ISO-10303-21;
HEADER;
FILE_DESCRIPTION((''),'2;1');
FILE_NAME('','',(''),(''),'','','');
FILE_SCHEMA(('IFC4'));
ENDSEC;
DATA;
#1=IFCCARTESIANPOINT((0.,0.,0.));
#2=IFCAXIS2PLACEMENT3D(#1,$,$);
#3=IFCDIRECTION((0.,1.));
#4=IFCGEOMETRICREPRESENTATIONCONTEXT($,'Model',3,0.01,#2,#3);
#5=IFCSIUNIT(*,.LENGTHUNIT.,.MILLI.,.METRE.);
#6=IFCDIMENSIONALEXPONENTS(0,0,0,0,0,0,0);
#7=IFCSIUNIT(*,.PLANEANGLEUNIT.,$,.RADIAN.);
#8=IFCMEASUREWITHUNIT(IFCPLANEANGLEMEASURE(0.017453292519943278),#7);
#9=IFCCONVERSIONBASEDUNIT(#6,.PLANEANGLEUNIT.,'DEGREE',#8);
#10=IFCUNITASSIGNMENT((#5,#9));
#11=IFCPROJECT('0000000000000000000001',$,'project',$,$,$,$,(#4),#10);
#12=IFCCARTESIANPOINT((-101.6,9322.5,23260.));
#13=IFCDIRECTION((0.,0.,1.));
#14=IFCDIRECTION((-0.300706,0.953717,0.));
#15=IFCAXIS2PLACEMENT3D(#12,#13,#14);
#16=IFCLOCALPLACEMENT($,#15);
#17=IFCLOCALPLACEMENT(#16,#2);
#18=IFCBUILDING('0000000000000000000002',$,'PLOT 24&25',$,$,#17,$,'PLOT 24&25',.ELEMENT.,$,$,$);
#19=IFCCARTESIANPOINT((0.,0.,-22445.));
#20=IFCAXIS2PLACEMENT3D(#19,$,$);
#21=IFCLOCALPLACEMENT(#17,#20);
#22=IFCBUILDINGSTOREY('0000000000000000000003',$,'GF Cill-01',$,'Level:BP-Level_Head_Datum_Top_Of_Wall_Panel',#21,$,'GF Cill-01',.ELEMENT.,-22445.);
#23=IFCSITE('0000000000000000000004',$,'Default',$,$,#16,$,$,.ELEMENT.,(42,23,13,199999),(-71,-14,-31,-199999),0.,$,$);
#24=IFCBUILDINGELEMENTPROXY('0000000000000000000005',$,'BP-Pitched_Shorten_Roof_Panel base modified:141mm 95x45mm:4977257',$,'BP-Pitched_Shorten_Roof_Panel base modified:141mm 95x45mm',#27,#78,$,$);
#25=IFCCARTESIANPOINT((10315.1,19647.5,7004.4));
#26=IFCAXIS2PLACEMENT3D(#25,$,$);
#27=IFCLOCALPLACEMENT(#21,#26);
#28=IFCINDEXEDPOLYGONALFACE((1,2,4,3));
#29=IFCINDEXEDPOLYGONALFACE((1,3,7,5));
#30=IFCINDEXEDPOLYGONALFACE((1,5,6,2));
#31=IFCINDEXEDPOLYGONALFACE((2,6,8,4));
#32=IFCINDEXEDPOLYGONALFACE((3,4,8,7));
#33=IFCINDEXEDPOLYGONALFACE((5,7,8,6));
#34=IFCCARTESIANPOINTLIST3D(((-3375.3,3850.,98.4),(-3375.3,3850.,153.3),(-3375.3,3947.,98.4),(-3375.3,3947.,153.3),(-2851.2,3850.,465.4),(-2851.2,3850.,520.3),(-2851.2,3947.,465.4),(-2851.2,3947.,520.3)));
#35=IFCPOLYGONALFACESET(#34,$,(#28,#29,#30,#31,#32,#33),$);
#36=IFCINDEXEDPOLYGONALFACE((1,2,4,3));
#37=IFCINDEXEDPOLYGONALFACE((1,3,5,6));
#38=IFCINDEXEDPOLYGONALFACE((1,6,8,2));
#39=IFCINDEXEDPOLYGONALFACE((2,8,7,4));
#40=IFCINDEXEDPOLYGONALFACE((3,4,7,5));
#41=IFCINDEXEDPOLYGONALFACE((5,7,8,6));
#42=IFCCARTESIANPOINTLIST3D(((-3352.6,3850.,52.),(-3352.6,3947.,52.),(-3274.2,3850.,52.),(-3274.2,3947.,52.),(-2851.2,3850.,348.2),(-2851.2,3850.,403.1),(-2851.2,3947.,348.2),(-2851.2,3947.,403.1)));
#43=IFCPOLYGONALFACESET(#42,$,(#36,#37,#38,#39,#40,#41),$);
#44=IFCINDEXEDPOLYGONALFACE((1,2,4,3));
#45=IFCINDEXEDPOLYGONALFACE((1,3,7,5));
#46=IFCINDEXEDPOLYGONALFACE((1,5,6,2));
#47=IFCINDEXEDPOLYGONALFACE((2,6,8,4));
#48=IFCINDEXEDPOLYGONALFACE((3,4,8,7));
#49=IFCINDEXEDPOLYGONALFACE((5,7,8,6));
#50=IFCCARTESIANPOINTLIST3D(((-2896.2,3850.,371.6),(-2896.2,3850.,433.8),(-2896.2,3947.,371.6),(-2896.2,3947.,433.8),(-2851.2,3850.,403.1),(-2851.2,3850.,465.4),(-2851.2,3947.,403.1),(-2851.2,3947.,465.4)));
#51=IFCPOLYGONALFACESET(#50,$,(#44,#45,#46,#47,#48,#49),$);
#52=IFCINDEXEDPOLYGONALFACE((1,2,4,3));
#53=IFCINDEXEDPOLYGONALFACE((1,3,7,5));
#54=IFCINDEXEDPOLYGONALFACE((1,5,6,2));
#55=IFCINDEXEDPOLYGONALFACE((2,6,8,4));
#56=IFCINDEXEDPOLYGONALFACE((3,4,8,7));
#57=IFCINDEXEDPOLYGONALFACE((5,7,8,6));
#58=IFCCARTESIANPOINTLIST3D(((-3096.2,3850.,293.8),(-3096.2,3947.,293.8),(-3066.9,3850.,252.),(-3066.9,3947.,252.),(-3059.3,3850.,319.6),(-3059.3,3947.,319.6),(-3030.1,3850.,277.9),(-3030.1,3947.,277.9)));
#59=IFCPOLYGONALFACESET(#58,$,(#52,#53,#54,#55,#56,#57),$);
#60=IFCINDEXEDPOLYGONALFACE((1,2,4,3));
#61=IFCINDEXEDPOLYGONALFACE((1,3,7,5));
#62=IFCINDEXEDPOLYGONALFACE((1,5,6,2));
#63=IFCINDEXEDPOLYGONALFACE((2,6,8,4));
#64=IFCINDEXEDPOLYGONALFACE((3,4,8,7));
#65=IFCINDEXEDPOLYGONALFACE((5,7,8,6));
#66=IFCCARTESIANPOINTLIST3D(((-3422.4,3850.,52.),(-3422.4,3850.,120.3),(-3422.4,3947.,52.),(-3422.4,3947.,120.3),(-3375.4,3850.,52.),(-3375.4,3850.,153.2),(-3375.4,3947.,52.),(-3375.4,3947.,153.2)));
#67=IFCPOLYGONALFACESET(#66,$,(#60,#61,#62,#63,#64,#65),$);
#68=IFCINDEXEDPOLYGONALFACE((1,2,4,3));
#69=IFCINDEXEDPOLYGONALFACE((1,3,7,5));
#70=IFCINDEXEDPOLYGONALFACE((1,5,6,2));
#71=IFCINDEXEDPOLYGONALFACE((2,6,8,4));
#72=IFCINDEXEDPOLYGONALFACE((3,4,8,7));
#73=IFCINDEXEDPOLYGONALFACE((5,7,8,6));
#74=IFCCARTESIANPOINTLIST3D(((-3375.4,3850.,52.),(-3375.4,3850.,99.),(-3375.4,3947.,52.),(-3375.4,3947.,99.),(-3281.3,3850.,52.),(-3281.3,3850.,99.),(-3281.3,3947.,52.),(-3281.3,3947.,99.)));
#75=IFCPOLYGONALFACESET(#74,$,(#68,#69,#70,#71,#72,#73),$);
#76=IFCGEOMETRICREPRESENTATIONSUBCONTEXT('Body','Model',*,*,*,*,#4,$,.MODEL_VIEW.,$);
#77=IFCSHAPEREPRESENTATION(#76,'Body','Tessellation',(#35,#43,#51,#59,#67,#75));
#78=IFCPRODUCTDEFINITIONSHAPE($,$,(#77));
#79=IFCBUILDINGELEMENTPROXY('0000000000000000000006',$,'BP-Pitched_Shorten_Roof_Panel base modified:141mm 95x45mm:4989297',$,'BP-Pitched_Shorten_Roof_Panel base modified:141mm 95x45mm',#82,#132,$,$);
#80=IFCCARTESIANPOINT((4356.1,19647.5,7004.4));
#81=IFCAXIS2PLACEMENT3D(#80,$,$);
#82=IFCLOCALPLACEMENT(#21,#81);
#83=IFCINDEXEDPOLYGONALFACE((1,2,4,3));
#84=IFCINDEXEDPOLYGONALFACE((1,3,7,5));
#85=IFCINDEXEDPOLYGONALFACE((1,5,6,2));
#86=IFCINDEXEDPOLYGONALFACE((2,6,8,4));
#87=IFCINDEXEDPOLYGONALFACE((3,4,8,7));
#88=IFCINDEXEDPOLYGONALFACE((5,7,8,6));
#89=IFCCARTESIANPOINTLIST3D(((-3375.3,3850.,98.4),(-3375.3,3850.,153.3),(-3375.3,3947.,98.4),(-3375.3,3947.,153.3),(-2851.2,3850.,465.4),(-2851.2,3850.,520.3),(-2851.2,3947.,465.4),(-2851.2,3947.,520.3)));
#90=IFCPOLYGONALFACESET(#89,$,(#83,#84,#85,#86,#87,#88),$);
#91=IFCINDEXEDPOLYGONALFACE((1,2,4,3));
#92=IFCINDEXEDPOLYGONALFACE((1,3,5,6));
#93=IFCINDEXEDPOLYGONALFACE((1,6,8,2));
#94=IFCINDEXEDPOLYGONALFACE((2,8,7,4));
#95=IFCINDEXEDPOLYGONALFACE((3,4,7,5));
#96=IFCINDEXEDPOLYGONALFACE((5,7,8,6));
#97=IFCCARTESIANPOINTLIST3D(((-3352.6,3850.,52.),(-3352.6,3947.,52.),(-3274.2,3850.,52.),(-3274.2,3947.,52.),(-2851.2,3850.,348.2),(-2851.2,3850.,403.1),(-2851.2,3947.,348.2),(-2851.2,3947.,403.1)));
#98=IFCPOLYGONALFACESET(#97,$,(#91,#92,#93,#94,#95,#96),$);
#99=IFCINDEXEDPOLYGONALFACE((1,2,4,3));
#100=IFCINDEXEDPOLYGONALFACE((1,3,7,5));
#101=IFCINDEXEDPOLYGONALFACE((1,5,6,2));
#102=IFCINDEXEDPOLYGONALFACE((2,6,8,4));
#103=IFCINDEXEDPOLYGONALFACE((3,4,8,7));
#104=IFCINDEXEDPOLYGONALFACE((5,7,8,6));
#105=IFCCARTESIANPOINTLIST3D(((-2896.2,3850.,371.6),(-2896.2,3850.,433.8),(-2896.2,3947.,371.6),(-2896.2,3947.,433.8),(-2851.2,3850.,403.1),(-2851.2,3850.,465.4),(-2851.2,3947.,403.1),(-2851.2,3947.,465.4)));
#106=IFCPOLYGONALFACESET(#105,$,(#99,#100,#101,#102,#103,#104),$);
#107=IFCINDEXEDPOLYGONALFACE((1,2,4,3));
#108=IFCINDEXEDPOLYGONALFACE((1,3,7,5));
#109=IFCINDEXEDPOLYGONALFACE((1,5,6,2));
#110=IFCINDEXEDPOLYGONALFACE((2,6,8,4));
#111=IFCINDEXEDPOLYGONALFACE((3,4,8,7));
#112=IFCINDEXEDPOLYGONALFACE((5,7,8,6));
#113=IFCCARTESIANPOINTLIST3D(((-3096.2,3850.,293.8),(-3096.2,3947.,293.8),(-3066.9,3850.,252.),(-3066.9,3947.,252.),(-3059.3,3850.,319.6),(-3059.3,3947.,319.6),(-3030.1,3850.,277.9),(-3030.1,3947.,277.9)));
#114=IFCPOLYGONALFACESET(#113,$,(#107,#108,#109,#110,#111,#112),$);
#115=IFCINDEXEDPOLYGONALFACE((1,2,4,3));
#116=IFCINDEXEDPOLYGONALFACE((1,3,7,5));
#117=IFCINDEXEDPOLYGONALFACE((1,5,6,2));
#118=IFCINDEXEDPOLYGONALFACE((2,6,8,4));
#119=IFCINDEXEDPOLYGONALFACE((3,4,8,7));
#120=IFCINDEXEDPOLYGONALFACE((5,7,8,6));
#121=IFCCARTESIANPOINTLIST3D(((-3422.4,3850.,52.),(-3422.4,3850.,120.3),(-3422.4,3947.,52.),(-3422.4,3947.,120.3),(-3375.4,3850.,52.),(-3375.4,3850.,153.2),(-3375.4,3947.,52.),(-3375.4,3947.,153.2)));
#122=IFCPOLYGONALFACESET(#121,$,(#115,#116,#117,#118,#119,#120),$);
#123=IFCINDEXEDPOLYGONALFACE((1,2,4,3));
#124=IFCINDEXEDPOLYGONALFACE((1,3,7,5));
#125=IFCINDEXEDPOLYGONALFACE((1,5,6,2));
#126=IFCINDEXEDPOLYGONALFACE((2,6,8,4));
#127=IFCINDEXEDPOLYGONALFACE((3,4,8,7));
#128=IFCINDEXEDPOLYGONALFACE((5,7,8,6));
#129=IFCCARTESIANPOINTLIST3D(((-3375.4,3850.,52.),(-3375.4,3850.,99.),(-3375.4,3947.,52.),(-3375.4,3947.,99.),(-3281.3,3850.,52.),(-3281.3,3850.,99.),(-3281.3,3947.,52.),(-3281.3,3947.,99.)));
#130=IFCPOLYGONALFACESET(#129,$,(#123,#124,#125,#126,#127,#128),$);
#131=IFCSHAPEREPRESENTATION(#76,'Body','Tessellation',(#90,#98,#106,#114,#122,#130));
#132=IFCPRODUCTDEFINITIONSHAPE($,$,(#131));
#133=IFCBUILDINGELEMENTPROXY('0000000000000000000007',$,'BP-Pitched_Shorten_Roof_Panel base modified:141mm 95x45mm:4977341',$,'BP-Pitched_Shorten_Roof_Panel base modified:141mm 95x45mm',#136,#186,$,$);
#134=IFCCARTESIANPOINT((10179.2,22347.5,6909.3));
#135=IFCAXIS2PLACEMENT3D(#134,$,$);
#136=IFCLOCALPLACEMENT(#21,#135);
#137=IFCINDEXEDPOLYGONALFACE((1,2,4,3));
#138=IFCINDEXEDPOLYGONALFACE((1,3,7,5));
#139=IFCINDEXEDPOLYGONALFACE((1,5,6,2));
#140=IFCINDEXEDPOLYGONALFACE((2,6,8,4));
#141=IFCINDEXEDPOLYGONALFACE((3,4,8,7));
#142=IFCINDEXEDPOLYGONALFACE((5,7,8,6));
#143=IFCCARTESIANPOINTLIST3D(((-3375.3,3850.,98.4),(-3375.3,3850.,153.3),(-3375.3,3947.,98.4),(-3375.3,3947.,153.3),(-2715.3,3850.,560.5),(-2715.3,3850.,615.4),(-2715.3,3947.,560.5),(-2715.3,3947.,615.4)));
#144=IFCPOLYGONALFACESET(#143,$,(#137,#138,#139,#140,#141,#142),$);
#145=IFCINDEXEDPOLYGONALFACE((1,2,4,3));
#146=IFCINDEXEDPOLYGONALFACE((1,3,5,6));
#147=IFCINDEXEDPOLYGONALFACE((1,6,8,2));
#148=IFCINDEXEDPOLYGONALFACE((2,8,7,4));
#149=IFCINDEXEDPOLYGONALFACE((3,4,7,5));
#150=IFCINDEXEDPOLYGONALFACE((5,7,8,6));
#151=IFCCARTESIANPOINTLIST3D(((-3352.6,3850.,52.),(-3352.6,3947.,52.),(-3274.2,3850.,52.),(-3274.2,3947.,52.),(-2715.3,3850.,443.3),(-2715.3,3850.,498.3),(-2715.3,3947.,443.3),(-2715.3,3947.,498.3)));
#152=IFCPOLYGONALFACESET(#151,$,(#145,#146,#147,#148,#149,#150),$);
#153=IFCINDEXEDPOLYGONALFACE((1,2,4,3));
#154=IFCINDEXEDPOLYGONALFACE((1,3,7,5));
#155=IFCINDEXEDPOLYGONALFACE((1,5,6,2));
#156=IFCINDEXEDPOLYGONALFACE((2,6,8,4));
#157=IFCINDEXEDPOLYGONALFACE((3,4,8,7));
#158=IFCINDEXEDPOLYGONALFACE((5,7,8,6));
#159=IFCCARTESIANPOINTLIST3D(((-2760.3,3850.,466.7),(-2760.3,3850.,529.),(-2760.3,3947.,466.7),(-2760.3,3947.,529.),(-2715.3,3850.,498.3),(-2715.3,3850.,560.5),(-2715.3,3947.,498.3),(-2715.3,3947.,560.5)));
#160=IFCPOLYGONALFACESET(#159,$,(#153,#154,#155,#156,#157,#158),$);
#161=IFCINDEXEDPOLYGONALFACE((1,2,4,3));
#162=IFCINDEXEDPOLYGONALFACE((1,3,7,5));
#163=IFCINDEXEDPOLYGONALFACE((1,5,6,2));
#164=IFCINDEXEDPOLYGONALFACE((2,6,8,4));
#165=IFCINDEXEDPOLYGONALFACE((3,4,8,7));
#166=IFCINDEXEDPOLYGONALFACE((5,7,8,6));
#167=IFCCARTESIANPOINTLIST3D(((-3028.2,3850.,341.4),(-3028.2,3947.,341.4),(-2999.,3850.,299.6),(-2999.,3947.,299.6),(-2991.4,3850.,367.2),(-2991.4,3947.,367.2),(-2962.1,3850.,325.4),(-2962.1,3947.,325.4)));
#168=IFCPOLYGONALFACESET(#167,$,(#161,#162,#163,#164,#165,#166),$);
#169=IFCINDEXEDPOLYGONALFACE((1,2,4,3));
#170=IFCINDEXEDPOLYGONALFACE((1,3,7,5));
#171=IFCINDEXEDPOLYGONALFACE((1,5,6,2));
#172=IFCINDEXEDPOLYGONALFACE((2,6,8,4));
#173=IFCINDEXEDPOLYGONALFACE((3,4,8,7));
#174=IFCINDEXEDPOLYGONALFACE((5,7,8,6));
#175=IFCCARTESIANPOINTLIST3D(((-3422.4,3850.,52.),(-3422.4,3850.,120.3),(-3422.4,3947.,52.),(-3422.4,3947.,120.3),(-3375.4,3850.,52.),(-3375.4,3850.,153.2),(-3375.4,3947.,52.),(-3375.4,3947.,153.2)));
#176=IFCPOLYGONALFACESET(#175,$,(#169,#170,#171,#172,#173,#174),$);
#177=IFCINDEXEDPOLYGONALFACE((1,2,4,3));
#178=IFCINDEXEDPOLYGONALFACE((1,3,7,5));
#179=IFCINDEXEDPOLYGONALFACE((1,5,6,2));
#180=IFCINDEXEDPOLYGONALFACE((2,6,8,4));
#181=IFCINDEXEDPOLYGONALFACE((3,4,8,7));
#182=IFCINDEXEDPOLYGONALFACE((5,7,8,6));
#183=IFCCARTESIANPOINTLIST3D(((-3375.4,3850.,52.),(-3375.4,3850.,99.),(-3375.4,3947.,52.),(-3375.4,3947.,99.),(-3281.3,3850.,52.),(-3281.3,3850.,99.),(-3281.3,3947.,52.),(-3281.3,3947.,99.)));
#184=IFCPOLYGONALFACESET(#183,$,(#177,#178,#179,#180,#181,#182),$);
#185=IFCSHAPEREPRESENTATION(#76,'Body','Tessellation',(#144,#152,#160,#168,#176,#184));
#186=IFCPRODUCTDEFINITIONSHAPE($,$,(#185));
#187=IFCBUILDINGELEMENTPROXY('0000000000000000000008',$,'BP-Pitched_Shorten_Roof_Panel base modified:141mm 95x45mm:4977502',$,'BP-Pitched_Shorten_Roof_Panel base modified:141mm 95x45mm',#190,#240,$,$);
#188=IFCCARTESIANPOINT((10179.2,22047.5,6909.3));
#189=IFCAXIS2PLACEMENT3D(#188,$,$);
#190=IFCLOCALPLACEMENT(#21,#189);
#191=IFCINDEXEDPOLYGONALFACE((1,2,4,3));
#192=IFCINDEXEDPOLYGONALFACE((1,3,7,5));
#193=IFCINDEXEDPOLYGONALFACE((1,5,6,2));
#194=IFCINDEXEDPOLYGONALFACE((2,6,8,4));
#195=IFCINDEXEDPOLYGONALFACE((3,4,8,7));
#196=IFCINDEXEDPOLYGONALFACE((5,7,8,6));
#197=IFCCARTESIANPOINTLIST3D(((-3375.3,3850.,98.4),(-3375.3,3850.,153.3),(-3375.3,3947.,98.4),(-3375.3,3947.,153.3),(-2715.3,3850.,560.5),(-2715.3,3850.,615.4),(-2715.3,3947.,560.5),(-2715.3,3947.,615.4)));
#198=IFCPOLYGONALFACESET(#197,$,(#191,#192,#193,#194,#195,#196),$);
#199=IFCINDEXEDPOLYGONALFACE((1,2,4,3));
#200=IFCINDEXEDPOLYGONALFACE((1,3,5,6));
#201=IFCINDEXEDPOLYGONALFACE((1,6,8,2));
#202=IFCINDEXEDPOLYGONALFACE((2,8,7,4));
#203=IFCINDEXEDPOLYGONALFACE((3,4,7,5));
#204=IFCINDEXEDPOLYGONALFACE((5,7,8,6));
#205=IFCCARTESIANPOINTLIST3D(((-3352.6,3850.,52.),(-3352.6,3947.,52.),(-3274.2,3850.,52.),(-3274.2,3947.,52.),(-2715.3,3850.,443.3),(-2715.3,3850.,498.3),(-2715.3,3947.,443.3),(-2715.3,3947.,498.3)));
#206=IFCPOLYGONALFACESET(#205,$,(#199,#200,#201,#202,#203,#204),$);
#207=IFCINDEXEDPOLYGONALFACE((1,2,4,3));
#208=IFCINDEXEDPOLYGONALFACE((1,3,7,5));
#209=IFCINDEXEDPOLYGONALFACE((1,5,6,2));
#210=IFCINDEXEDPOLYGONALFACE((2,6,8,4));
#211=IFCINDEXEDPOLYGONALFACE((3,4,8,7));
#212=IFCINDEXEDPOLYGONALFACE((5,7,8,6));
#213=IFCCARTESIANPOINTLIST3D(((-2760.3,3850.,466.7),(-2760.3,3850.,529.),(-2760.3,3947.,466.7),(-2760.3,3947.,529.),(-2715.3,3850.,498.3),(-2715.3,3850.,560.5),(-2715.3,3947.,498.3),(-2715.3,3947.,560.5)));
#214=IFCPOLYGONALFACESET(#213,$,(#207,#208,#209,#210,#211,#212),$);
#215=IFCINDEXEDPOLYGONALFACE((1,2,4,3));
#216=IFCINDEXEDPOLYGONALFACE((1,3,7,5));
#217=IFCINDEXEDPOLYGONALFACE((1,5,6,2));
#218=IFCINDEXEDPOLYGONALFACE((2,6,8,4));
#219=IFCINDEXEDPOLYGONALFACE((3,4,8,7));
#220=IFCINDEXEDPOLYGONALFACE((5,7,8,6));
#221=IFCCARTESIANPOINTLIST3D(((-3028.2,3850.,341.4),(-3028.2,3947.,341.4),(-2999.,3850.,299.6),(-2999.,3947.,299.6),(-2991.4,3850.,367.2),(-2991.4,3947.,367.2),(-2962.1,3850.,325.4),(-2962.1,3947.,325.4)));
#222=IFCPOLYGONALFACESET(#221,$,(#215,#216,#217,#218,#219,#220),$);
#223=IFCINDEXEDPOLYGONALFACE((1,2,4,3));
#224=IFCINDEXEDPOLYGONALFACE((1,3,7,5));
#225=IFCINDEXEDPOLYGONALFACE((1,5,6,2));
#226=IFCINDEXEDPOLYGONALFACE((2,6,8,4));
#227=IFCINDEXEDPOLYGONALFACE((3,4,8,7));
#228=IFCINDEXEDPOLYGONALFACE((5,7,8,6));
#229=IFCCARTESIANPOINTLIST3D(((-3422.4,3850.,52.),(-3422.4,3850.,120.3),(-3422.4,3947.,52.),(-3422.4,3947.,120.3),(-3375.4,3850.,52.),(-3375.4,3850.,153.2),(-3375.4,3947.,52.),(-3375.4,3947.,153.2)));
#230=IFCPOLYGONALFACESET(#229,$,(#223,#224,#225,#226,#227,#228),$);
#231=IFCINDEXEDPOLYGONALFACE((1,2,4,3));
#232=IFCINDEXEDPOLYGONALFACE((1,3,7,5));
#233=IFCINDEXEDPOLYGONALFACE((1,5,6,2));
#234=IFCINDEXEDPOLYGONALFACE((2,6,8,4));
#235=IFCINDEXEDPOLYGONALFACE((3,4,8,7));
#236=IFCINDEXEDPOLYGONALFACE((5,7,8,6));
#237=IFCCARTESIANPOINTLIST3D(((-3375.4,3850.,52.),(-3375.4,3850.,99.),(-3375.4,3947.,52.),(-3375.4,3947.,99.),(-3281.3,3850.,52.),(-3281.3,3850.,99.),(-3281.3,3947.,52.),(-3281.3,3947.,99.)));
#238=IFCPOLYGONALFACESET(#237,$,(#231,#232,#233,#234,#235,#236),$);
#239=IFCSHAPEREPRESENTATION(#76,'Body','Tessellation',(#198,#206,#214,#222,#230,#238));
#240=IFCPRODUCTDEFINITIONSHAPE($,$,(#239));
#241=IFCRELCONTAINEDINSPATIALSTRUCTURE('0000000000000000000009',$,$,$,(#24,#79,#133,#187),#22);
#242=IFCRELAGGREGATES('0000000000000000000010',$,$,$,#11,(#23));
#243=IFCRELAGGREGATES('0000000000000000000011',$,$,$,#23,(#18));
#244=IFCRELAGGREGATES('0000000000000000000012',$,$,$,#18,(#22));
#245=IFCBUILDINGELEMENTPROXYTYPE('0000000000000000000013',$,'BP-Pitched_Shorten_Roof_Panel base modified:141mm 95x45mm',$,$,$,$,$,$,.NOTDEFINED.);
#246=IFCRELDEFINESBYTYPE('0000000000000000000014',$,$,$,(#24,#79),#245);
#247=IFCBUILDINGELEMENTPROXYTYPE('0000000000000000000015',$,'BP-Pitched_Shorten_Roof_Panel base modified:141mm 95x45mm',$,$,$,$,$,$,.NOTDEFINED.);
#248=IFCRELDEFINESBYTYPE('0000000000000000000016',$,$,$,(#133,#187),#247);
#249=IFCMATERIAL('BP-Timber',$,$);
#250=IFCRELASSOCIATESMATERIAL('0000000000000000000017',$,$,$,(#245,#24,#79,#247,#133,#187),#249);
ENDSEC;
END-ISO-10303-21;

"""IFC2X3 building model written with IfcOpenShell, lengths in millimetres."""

from ifc_helpers import new_model, entity, si_unit, converted_unit, direction, frame, frame_2d, origin, origin_2d_with_axis, place, context, subcontext, project, spatial, polyline, rectangle, outline, extrude, source, transform, mapped, material, type_object, type_shapes, element, save


model = new_model("IFC2X3")

# Units and contexts
model_context = context("Model", 3, precision=0.01, world=origin(), true_north=direction((0.0, 1.0)))
body_context = subcontext(model_context, "Body", "Model", "MODEL_VIEW")
ifc_project = project(units=[si_unit("LENGTHUNIT", "METRE", prefix="MILLI"), converted_unit("PLANEANGLEUNIT", "DEGREE", entity("IfcPlaneAngleMeasure", 0.017453292519943278), si_unit("PLANEANGLEUNIT", "RADIAN"), dimensions=[0, 0, 0, 0, 0, 0, 0])], contexts=[model_context])

# Site, building, storey
site_placement = place(None, frame((-101.6, 9322.5, 23260.0), z_axis=(0.0, 0.0, 1.0), x_axis=(-0.300706, 0.953717, 0.0)))
site = spatial("IfcSite", under=ifc_project, at=site_placement, Name="Default", CompositionType="ELEMENT", RefLatitude=(42, 23, 13, 199999), RefLongitude=(-71, -14, -31, -199999), RefElevation=0.0)
building_placement = place(site_placement, origin())
building = spatial("IfcBuilding", under=site, at=building_placement, Name="PLOT 24&25", LongName="PLOT 24&25", CompositionType="ELEMENT")
storey_placement = place(building_placement, frame((0.0, 0.0, -22445.0)))
storey = spatial("IfcBuildingStorey", under=building, at=storey_placement, Name="GF Cill-01", ObjectType="Level:BP-Level_Head_Datum_Top_Of_Wall_Panel", LongName="GF Cill-01", CompositionType="ELEMENT", Elevation=-22445.0)

# Shared definitions
ifc_material_1 = material(Name="BP-Timber")

# Building element proxies
building_element_proxy_type_1 = type_object("IfcBuildingElementProxyType", Name="BP-Pitched_Shorten_Roof_Panel base modified:141mm 95x45mm", PredefinedType="NOTDEFINED", material=ifc_material_1)
shared_shape_1 = source(origin(), body_context, "Body", "SweptSolid", [
    extrude(outline(polyline([(-211.0, -262.0), (-156.0, -262.0), (211.0, 262.0), (156.0, 262.0), (-211.0, -262.0)])), frame((-3113.3, 3850.0, 309.3), z_axis=(0.0, 1.0, 0.0), x_axis=(0.0, 0.0, -1.0)), (0.0, 0.0, 1.0), 97.0),
    extrude(outline(polyline([(-189.3, -231.1), (-134.3, -231.1), (161.8, 191.9), (161.8, 270.3), (-189.3, -231.1)])), frame((-3082.3, 3850.0, 213.8), z_axis=(0.0, 1.0, 0.0), x_axis=(0.0, 0.0, -1.0)), (0.0, 0.0, 1.0), 97.0),
    extrude(outline(polyline([(-9.6, -25.5), (45.3, -25.5), (9.6, 25.5), (-45.3, 25.5), (-9.6, -25.5)])), frame((-2873.7, 3850.0, 418.5), z_axis=(0.0, 1.0, 0.0), x_axis=(0.819152, 0.0, 0.573576)), (0.0, 0.0, 1.0), 97.0),
    extrude(rectangle(XDim=51.0, YDim=45.0, at=frame_2d((0.0, 0.0), x_axis=(1.0, 0.0))), frame((-3063.1, 3850.0, 285.8), z_axis=(0.0, 1.0, 0.0), x_axis=(0.573576, 0.0, -0.819152)), (0.0, 0.0, 1.0), 97.0),
    extrude(outline(polyline([(-58.9, -23.5), (42.4, -23.5), (42.4, 23.5), (-25.9, 23.5), (-58.9, -23.5)])), frame((-3398.9, 3850.0, 94.4), z_axis=(0.0, 1.0, 0.0), x_axis=(0.0, 0.0, -1.0)), (0.0, 0.0, 1.0), 97.0),
    extrude(rectangle(XDim=97.0, YDim=94.1, at=frame_2d((0.0, 0.0), x_axis=(1.0, 0.0))), frame((-3328.4, 3898.5, 52.0), z_axis=(0.0, 0.0, 1.0), x_axis=(0.0, 1.0, 0.0)), (0.0, 0.0, 1.0), 47.0),
])
type_shapes(building_element_proxy_type_1, [shared_shape_1])
for number, where, name in (
    (1, (10315.1, 19647.5, 7004.4), "BP-Pitched_Shorten_Roof_Panel base modified:141mm 95x45mm:4977257"),
    (2, (4356.1, 19647.5, 7004.4), "BP-Pitched_Shorten_Roof_Panel base modified:141mm 95x45mm:4989297"),
):
    element("IfcBuildingElementProxy", number, at=place(storey_placement, frame(where)), inside=storey, type_object=building_element_proxy_type_1, material=ifc_material_1, Name=name, ObjectType="BP-Pitched_Shorten_Roof_Panel base modified:141mm 95x45mm", context=body_context, shape_type="MappedRepresentation", body=[
        mapped(shared_shape_1, transform((0.0, 0.0, 0.0), scale=1.0)),
    ])
building_element_proxy_type_2 = type_object("IfcBuildingElementProxyType", Name="BP-Pitched_Shorten_Roof_Panel base modified:141mm 95x45mm", PredefinedType="NOTDEFINED", material=ifc_material_1)
shared_shape_2 = source(origin(), body_context, "Body", "SweptSolid", [
    extrude(outline(polyline([(-258.5, -330.0), (-203.6, -330.0), (258.5, 330.0), (203.6, 330.0), (-258.5, -330.0)])), frame((-3045.3, 3850.0, 356.9), z_axis=(0.0, 1.0, 0.0), x_axis=(0.0, 0.0, -1.0)), (0.0, 0.0, 1.0), 97.0),
    extrude(outline(polyline([(-236.9, -299.0), (-181.9, -299.0), (209.4, 259.8), (209.4, 338.3), (-236.9, -299.0)])), frame((-3014.4, 3850.0, 261.4), z_axis=(0.0, 1.0, 0.0), x_axis=(0.0, 0.0, -1.0)), (0.0, 0.0, 1.0), 97.0),
    extrude(outline(polyline([(-9.6, -25.5), (45.3, -25.5), (9.6, 25.5), (-45.3, 25.5), (-9.6, -25.5)])), frame((-2737.8, 3850.0, 513.6), z_axis=(0.0, 1.0, 0.0), x_axis=(0.819152, 0.0, 0.573576)), (0.0, 0.0, 1.0), 97.0),
    extrude(rectangle(XDim=51.0, YDim=45.0, at=origin_2d_with_axis()), frame((-2995.2, 3850.0, 333.4), z_axis=(0.0, 1.0, 0.0), x_axis=(0.573576, 0.0, -0.819152)), (0.0, 0.0, 1.0), 97.0),
    extrude(outline(polyline([(-58.9, -23.5), (42.4, -23.5), (42.4, 23.5), (-25.9, 23.5), (-58.9, -23.5)])), frame((-3398.9, 3850.0, 94.4), z_axis=(0.0, 1.0, 0.0), x_axis=(0.0, 0.0, -1.0)), (0.0, 0.0, 1.0), 97.0),
    extrude(rectangle(XDim=97.0, YDim=94.1, at=frame_2d((0.0, 0.0), x_axis=(1.0, 0.0))), frame((-3328.4, 3898.5, 52.0), z_axis=(0.0, 0.0, 1.0), x_axis=(0.0, 1.0, 0.0)), (0.0, 0.0, 1.0), 47.0),
])
type_shapes(building_element_proxy_type_2, [shared_shape_2])
for number, where, name in (
    (3, (10179.2, 22347.5, 6909.3), "BP-Pitched_Shorten_Roof_Panel base modified:141mm 95x45mm:4977341"),
    (4, (10179.2, 22047.5, 6909.3), "BP-Pitched_Shorten_Roof_Panel base modified:141mm 95x45mm:4977502"),
):
    element("IfcBuildingElementProxy", number, at=place(storey_placement, frame(where)), inside=storey, type_object=building_element_proxy_type_2, material=ifc_material_1, Name=name, ObjectType="BP-Pitched_Shorten_Roof_Panel base modified:141mm 95x45mm", context=body_context, shape_type="MappedRepresentation", body=[
        mapped(shared_shape_2, transform((0.0, 0.0, 0.0), scale=1.0)),
    ])

save(model, "model.ifc")
